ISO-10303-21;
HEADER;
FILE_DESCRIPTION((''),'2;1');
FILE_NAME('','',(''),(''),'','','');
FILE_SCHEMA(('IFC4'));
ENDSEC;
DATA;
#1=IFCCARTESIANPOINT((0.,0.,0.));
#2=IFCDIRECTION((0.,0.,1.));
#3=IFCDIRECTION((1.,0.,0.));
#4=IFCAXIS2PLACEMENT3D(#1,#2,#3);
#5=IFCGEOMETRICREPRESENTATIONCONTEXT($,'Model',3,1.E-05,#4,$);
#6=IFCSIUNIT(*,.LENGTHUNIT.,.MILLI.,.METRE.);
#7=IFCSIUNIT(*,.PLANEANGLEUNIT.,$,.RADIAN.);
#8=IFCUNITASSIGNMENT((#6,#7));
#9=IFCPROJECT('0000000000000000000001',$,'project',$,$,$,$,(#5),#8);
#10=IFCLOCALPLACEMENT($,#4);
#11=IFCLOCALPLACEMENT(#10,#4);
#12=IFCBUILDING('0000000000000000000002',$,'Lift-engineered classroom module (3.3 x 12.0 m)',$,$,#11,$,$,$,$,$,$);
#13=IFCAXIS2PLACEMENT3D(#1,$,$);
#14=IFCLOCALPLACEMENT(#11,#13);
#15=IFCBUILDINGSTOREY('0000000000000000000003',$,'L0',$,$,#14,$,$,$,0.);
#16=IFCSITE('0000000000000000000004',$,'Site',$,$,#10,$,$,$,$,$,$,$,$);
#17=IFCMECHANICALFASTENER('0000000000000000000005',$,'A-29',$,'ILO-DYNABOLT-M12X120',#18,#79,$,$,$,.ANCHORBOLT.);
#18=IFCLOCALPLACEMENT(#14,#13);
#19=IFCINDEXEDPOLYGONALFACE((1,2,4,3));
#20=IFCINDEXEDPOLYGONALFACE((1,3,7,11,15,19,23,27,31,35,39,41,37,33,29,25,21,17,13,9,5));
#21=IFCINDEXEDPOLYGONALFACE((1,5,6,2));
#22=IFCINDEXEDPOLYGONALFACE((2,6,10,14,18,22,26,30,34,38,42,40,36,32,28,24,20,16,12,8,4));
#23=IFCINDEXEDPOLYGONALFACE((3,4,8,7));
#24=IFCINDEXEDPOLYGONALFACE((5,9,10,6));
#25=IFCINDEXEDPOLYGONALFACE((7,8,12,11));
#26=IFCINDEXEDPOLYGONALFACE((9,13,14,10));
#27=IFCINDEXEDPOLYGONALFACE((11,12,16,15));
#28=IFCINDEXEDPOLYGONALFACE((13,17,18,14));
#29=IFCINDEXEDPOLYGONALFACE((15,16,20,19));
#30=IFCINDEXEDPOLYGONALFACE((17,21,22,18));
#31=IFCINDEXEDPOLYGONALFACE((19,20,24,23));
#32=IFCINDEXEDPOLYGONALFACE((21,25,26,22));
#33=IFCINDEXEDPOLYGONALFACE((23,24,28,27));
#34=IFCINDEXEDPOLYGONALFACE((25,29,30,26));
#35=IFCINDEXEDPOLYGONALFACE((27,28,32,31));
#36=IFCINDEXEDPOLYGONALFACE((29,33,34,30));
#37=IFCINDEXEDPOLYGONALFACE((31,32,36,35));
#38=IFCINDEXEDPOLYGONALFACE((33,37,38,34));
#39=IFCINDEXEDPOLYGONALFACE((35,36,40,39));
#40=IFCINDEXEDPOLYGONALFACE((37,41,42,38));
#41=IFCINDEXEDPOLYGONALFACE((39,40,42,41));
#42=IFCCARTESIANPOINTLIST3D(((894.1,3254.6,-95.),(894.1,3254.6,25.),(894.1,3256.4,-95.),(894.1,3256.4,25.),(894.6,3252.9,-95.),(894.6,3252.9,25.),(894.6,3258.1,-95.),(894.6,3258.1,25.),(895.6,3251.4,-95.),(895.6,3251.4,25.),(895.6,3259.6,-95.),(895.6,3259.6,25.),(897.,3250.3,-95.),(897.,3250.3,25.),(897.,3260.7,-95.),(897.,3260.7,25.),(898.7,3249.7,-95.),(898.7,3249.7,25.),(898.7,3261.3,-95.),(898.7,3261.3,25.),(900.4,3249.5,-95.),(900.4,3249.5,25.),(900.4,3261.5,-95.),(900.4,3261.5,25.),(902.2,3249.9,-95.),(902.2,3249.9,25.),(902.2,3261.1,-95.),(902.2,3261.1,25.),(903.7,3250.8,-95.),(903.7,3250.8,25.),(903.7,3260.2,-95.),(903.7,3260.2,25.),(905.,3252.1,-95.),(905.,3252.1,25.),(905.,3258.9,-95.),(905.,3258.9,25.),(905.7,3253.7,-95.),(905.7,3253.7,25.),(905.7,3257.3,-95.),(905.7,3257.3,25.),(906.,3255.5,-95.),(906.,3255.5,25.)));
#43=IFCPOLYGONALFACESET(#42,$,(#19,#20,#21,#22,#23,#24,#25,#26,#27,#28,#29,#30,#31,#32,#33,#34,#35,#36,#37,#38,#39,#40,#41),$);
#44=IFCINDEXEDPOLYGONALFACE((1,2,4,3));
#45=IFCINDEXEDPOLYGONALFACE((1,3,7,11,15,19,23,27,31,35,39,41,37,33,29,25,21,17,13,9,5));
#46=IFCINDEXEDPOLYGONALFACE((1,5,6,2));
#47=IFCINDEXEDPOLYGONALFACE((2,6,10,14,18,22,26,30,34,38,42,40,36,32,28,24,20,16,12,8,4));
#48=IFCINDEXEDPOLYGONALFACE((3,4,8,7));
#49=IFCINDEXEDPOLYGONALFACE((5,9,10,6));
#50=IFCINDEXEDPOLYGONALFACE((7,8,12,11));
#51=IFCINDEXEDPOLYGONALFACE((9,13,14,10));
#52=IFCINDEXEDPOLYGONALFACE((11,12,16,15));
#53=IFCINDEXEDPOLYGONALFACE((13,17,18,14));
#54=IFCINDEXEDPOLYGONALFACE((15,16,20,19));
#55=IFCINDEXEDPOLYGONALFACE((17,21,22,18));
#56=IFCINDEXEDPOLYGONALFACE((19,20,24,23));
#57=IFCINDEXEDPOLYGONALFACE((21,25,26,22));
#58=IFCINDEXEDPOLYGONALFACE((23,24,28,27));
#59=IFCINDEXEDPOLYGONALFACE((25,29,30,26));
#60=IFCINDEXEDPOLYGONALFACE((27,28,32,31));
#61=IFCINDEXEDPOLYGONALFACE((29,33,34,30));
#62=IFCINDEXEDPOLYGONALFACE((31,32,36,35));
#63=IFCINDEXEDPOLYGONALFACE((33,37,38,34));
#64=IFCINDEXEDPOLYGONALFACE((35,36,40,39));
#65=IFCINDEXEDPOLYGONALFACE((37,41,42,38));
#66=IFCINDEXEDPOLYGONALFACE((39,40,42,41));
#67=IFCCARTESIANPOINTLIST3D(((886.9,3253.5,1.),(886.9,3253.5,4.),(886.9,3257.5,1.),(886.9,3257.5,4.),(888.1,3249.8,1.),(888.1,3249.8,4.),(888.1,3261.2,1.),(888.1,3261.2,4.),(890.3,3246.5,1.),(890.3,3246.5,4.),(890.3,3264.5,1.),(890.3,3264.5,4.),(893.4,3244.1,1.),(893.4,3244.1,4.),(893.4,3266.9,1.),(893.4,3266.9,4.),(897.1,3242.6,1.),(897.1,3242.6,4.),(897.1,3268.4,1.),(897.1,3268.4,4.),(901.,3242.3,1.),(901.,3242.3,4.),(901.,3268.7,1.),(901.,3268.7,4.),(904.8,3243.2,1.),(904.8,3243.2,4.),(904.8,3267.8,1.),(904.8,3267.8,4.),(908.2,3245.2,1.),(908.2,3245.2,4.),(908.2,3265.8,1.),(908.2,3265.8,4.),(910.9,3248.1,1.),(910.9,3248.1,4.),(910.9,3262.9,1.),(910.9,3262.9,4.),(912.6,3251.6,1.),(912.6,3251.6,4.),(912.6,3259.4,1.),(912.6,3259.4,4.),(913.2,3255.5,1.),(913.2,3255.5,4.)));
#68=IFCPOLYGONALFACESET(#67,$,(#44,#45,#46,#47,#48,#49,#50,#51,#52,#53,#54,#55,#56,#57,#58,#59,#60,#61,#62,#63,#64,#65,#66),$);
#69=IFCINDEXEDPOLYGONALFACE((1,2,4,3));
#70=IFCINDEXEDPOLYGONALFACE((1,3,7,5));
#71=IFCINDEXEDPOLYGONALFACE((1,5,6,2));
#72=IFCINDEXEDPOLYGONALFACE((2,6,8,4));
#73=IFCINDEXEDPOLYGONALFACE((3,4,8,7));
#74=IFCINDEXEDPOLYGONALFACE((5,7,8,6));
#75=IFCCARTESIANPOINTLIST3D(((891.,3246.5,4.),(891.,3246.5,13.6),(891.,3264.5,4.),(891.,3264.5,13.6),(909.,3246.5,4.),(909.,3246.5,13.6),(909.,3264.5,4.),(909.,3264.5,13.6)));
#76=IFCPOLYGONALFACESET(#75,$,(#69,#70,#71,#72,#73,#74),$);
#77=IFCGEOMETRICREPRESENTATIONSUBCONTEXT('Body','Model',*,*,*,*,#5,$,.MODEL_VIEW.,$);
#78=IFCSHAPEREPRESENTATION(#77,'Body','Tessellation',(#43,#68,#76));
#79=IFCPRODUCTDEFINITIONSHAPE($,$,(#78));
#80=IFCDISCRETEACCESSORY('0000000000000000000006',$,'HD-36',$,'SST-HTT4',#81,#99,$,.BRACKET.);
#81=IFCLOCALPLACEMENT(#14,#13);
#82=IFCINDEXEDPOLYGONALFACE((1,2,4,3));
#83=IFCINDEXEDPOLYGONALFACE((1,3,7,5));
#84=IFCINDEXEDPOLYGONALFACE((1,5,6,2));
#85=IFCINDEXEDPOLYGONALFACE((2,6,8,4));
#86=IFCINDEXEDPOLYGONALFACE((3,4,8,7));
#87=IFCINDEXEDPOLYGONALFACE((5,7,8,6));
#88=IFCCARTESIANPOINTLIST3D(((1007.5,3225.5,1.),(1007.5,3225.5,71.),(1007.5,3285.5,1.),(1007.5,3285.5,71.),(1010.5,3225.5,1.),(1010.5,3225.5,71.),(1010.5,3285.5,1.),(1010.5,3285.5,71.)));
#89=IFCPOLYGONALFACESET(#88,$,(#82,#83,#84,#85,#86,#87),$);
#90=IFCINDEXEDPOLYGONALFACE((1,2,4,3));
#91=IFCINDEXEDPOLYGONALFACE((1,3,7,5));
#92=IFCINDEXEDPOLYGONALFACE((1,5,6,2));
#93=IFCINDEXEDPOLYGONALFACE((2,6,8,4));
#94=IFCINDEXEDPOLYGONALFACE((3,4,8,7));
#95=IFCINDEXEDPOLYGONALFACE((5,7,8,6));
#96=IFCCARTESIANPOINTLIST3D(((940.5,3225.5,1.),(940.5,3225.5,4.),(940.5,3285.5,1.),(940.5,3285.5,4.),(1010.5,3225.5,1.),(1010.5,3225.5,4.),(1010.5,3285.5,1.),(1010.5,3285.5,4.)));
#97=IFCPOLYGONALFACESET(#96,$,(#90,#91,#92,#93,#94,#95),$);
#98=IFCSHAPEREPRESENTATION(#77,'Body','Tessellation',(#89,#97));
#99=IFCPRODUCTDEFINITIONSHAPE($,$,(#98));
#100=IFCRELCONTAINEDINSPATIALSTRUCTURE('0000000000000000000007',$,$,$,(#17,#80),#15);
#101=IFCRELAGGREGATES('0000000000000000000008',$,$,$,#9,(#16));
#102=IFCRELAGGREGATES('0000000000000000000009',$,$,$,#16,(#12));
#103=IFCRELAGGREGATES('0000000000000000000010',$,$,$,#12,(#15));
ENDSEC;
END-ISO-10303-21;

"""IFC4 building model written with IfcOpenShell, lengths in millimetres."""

from ifc_helpers import new_model, si_unit, frame, frame_2d, origin, origin_with_axes, origin_2d, place, context, subcontext, project, spatial, rectangle, circle, extrude, element, save


model = new_model("IFC4")

# Units and contexts
model_context = context("Model", 3, precision=1e-05, world=origin_with_axes())
body_context = subcontext(model_context, "Body", "Model", "MODEL_VIEW")
ifc_project = project(units=[si_unit("LENGTHUNIT", "METRE", prefix="MILLI"), si_unit("PLANEANGLEUNIT", "RADIAN")], contexts=[model_context])

# Site, building, storey
site_placement = place(None, origin_with_axes())
site = spatial("IfcSite", under=ifc_project, at=site_placement, Name="Site")
building_placement = place(site_placement, origin_with_axes())
building = spatial("IfcBuilding", under=site, at=building_placement, Name="Lift-engineered classroom module (3.3 x 12.0 m)")
storey_placement = place(building_placement, origin())
storey = spatial("IfcBuildingStorey", under=building, at=storey_placement, Name="L0", Elevation=0.0)

# Mechanical fastener
mechanical_fastener_1_placement = place(None, frame((900.0, 3255.5, 0.0), z_axis=(0.0, 0.0, 1.0), x_axis=(1.0, 0.0, 0.0)))
element("IfcMechanicalFastener", 1, at=mechanical_fastener_1_placement, inside=storey, Name="A-29", ObjectType="ILO-DYNABOLT-M12X120", PredefinedType="ANCHORBOLT", context=body_context, shape_type="SweptSolid", body=[
    extrude(circle(Radius=6.0, at=origin_2d()), frame((0.0, 0.0, -95.0), z_axis=(0.0, 0.0, 1.0), x_axis=(1.0, 0.0, 0.0)), (0.0, 0.0, 1.0), 120.0),
    extrude(circle(Radius=13.2, at=origin_2d()), frame((0.0, 0.0, 1.0), z_axis=(0.0, 0.0, 1.0), x_axis=(1.0, 0.0, 0.0)), (0.0, 0.0, 1.0), 3.0),
    extrude(rectangle(XDim=18.0, YDim=18.0, at=origin_2d()), frame((0.0, 0.0, 4.0), z_axis=(0.0, 0.0, 1.0), x_axis=(1.0, 0.0, 0.0)), (0.0, 0.0, 1.0), 9.6),
])

# Discrete accessory
discrete_accessory_1_placement = place(None, frame((1010.5, 3255.5, 0.0), z_axis=(0.0, 0.0, 1.0), x_axis=(-1.0, 0.0, 0.0)))
element("IfcDiscreteAccessory", 2, at=discrete_accessory_1_placement, inside=storey, Name="HD-36", ObjectType="SST-HTT4", PredefinedType="BRACKET", context=body_context, shape_type="SweptSolid", body=[
    extrude(rectangle(XDim=3.0, YDim=60.0, at=frame_2d((1.5, 0.0))), frame((0.0, 0.0, 1.0), z_axis=(0.0, 0.0, 1.0), x_axis=(1.0, 0.0, 0.0)), (0.0, 0.0, 1.0), 70.0),
    extrude(rectangle(XDim=70.0, YDim=60.0, at=frame_2d((35.0, 0.0))), frame((0.0, 0.0, 1.0), z_axis=(0.0, 0.0, 1.0), x_axis=(1.0, 0.0, 0.0)), (0.0, 0.0, 1.0), 3.0),
])

save(model, "model.ifc")
